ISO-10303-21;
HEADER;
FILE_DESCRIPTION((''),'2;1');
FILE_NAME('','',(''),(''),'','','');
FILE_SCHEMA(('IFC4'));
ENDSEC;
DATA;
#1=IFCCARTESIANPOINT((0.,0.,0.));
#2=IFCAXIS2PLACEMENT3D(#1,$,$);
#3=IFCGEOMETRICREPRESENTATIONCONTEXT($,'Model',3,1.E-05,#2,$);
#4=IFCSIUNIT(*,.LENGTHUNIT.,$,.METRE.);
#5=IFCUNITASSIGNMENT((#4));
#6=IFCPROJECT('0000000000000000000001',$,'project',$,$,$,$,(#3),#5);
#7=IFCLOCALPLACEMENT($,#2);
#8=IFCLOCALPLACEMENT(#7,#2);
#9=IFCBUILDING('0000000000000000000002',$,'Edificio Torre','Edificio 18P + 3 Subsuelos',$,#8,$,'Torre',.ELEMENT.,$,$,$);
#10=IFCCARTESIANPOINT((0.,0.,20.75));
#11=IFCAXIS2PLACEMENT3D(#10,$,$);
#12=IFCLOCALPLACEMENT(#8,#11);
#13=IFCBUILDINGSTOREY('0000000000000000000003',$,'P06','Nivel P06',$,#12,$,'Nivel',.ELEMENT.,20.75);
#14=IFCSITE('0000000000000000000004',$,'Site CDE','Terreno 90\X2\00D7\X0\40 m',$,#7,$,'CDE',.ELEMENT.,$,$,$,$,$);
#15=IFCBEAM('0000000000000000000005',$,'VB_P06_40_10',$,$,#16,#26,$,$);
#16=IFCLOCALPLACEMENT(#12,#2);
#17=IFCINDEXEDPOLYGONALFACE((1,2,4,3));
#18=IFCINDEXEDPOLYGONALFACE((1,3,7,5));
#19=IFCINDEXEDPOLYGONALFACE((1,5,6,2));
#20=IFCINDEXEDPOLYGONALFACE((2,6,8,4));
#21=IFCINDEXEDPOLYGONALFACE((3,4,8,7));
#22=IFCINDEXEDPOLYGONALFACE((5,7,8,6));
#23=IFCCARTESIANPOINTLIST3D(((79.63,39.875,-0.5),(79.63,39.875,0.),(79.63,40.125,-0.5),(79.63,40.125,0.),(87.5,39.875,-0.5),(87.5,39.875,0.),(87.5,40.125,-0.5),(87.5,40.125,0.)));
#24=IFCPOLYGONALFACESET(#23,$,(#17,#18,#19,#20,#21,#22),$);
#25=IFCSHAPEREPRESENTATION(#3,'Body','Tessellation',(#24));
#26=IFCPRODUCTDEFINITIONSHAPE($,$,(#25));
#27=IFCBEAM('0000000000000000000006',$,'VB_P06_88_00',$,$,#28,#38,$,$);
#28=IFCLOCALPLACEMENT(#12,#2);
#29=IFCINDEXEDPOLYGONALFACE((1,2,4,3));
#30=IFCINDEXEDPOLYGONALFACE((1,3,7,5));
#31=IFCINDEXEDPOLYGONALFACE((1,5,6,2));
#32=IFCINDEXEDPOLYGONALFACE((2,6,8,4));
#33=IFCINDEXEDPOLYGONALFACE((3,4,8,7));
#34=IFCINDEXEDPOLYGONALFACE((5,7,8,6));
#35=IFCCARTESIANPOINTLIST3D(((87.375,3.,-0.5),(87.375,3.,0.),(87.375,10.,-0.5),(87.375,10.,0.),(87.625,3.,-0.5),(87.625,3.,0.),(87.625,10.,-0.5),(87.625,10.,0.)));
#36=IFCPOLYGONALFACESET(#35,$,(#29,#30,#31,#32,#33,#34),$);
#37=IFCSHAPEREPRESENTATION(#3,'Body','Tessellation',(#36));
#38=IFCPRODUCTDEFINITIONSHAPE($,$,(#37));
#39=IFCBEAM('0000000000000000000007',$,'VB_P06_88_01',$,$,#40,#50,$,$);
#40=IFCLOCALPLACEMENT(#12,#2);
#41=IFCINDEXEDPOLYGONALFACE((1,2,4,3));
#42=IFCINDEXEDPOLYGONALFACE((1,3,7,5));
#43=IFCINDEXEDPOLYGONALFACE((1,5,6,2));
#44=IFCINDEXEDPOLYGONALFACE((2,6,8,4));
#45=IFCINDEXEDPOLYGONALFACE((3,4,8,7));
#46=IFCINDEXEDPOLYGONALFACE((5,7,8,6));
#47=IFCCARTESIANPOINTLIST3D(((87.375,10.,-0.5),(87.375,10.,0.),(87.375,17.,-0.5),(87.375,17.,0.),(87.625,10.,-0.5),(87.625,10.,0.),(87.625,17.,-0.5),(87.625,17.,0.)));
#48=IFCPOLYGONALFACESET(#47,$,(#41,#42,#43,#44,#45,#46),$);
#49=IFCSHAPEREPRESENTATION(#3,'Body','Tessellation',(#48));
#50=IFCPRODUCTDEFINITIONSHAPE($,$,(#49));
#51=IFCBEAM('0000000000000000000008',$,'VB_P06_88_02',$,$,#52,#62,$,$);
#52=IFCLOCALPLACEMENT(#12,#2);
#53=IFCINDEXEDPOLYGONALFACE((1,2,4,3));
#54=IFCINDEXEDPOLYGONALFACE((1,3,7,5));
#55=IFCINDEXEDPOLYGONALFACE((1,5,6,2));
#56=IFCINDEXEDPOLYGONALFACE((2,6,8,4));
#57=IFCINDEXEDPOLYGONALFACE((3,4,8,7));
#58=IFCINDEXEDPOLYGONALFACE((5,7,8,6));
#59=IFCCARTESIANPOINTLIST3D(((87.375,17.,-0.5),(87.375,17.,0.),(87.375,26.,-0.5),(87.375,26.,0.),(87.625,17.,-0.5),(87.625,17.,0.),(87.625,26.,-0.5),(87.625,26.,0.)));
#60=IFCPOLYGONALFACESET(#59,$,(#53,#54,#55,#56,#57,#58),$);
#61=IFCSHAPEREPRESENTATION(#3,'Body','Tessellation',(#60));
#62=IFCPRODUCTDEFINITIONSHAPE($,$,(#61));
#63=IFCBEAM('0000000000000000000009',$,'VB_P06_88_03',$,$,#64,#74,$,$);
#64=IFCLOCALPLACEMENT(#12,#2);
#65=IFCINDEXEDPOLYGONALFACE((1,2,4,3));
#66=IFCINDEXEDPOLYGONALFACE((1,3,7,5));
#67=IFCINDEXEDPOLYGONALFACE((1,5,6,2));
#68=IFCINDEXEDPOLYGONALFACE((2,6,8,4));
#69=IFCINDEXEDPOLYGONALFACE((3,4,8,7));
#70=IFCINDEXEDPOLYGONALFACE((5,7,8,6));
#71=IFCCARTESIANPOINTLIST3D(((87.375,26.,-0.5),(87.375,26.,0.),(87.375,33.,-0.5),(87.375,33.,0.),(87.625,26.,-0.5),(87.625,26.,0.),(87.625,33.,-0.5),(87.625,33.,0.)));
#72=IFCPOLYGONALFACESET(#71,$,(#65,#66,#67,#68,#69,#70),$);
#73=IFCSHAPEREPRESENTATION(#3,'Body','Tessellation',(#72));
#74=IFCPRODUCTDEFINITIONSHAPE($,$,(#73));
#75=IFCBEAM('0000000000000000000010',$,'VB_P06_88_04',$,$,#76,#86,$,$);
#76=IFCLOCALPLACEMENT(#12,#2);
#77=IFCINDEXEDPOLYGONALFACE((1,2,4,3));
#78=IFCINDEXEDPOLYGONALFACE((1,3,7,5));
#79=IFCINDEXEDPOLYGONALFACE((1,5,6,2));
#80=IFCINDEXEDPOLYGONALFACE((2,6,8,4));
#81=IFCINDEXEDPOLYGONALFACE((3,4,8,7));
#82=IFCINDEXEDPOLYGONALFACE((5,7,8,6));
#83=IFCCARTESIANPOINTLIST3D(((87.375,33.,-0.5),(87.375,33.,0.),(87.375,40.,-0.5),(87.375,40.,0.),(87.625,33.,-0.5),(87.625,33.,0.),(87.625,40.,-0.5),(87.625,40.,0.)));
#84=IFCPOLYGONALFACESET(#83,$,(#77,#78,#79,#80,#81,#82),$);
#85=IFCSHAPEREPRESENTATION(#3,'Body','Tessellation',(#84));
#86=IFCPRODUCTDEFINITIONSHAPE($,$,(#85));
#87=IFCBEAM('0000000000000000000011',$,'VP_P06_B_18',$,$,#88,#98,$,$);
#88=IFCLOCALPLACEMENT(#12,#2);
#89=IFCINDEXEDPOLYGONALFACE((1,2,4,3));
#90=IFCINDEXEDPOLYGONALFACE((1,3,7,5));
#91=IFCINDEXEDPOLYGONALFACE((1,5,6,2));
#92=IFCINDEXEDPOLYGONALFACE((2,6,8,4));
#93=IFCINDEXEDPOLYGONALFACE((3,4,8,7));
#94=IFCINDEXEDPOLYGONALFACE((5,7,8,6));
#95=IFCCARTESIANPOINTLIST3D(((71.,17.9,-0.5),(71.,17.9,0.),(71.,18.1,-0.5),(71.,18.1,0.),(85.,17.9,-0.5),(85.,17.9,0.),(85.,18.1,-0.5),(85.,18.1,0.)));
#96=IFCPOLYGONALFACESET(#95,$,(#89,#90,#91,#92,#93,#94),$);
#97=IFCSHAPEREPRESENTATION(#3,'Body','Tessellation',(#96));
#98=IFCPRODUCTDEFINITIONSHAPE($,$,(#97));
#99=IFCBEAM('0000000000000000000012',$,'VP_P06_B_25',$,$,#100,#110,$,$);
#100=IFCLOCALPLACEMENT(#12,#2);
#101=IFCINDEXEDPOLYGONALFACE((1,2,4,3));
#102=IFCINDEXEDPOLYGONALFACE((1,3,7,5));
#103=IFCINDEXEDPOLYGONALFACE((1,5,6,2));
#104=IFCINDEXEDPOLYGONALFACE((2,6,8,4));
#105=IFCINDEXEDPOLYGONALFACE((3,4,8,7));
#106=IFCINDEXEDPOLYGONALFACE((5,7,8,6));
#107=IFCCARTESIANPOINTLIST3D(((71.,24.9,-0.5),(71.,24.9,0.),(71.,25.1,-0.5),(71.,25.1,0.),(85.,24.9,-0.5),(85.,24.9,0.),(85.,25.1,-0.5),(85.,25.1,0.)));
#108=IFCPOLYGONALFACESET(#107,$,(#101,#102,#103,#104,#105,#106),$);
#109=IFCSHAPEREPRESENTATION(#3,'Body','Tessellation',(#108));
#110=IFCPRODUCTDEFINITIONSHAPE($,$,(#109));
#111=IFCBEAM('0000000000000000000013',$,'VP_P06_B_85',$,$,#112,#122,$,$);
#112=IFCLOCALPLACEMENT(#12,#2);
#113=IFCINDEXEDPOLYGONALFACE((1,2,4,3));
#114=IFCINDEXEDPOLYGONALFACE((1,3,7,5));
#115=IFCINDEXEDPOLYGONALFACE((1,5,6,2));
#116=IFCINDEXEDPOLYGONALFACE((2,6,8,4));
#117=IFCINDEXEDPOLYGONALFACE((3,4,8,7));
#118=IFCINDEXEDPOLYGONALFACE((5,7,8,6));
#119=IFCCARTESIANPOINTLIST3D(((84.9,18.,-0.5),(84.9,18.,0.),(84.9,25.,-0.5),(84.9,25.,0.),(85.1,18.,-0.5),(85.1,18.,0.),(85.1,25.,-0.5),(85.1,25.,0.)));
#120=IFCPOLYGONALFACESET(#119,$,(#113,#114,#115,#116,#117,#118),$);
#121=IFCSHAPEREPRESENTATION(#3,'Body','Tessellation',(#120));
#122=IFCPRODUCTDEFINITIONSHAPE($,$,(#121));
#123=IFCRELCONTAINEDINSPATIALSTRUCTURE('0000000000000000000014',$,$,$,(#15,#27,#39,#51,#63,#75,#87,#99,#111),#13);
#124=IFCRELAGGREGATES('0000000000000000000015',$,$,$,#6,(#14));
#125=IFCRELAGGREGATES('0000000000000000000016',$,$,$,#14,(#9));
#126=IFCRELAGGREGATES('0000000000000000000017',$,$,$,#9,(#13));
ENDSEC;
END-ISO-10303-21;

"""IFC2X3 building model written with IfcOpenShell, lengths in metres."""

from ifc_helpers import new_model, si_unit, frame, origin, origin_2d, place, context, project, spatial, rectangle, extrude, element, save


model = new_model("IFC2X3")

# Units and contexts
model_context = context("Model", 3, precision=1e-05, world=origin())
ifc_project = project(units=[si_unit("LENGTHUNIT", "METRE")], contexts=[model_context])

# Site, building, storey
site_placement = place(None, origin())
site = spatial("IfcSite", under=ifc_project, at=site_placement, Name="Site CDE", Description="Terreno 90×40 m", LongName="CDE", CompositionType="ELEMENT")
building_placement = place(site_placement, origin())
building = spatial("IfcBuilding", under=site, at=building_placement, Name="Edificio Torre", Description="Edificio 18P + 3 Subsuelos", LongName="Torre", CompositionType="ELEMENT")
storey_placement = place(building_placement, frame((0.0, 0.0, 20.75)))
storey = spatial("IfcBuildingStorey", under=building, at=storey_placement, Name="P06", Description="Nivel P06", LongName="Nivel", CompositionType="ELEMENT", Elevation=20.75)

# Beams
beam_1_placement = place(storey_placement, frame((83.565, 40.0, -0.5)))
element("IfcBeam", 1, at=beam_1_placement, inside=storey, Name="VB_P06_40_10", context=model_context, shape_type="SweptSolid", body=[
    extrude(rectangle(XDim=7.87, YDim=0.25, at=origin_2d()), origin(), (0.0, 0.0, 1.0), 0.5),
])
for number, where, name in (
    (2, (87.5, 6.5, -0.5), "VB_P06_88_00"),
    (3, (87.5, 13.5, -0.5), "VB_P06_88_01"),
):
    element("IfcBeam", number, at=place(storey_placement, frame(where)), inside=storey, Name=name, context=model_context, shape_type="SweptSolid", body=[
        extrude(rectangle(XDim=0.25, YDim=7.0, at=origin_2d()), origin(), (0.0, 0.0, 1.0), 0.5),
    ])
beam_2_placement = place(storey_placement, frame((87.5, 21.5, -0.5)))
element("IfcBeam", 4, at=beam_2_placement, inside=storey, Name="VB_P06_88_02", context=model_context, shape_type="SweptSolid", body=[
    extrude(rectangle(XDim=0.25, YDim=9.0, at=origin_2d()), origin(), (0.0, 0.0, 1.0), 0.5),
])
for number, where, name in (
    (5, (87.5, 29.5, -0.5), "VB_P06_88_03"),
    (6, (87.5, 36.5, -0.5), "VB_P06_88_04"),
):
    element("IfcBeam", number, at=place(storey_placement, frame(where)), inside=storey, Name=name, context=model_context, shape_type="SweptSolid", body=[
        extrude(rectangle(XDim=0.25, YDim=7.0, at=origin_2d()), origin(), (0.0, 0.0, 1.0), 0.5),
    ])
for number, where, name in (
    (7, (78.0, 18.0, -0.5), "VP_P06_B_18"),
    (8, (78.0, 25.0, -0.5), "VP_P06_B_25"),
):
    element("IfcBeam", number, at=place(storey_placement, frame(where)), inside=storey, Name=name, context=model_context, shape_type="SweptSolid", body=[
        extrude(rectangle(XDim=14.0, YDim=0.2, at=origin_2d()), origin(), (0.0, 0.0, 1.0), 0.5),
    ])
beam_3_placement = place(storey_placement, frame((85.0, 21.5, -0.5)))
element("IfcBeam", 9, at=beam_3_placement, inside=storey, Name="VP_P06_B_85", context=model_context, shape_type="SweptSolid", body=[
    extrude(rectangle(XDim=0.2, YDim=7.0, at=origin_2d()), origin(), (0.0, 0.0, 1.0), 0.5),
])

save(model, "model.ifc")
